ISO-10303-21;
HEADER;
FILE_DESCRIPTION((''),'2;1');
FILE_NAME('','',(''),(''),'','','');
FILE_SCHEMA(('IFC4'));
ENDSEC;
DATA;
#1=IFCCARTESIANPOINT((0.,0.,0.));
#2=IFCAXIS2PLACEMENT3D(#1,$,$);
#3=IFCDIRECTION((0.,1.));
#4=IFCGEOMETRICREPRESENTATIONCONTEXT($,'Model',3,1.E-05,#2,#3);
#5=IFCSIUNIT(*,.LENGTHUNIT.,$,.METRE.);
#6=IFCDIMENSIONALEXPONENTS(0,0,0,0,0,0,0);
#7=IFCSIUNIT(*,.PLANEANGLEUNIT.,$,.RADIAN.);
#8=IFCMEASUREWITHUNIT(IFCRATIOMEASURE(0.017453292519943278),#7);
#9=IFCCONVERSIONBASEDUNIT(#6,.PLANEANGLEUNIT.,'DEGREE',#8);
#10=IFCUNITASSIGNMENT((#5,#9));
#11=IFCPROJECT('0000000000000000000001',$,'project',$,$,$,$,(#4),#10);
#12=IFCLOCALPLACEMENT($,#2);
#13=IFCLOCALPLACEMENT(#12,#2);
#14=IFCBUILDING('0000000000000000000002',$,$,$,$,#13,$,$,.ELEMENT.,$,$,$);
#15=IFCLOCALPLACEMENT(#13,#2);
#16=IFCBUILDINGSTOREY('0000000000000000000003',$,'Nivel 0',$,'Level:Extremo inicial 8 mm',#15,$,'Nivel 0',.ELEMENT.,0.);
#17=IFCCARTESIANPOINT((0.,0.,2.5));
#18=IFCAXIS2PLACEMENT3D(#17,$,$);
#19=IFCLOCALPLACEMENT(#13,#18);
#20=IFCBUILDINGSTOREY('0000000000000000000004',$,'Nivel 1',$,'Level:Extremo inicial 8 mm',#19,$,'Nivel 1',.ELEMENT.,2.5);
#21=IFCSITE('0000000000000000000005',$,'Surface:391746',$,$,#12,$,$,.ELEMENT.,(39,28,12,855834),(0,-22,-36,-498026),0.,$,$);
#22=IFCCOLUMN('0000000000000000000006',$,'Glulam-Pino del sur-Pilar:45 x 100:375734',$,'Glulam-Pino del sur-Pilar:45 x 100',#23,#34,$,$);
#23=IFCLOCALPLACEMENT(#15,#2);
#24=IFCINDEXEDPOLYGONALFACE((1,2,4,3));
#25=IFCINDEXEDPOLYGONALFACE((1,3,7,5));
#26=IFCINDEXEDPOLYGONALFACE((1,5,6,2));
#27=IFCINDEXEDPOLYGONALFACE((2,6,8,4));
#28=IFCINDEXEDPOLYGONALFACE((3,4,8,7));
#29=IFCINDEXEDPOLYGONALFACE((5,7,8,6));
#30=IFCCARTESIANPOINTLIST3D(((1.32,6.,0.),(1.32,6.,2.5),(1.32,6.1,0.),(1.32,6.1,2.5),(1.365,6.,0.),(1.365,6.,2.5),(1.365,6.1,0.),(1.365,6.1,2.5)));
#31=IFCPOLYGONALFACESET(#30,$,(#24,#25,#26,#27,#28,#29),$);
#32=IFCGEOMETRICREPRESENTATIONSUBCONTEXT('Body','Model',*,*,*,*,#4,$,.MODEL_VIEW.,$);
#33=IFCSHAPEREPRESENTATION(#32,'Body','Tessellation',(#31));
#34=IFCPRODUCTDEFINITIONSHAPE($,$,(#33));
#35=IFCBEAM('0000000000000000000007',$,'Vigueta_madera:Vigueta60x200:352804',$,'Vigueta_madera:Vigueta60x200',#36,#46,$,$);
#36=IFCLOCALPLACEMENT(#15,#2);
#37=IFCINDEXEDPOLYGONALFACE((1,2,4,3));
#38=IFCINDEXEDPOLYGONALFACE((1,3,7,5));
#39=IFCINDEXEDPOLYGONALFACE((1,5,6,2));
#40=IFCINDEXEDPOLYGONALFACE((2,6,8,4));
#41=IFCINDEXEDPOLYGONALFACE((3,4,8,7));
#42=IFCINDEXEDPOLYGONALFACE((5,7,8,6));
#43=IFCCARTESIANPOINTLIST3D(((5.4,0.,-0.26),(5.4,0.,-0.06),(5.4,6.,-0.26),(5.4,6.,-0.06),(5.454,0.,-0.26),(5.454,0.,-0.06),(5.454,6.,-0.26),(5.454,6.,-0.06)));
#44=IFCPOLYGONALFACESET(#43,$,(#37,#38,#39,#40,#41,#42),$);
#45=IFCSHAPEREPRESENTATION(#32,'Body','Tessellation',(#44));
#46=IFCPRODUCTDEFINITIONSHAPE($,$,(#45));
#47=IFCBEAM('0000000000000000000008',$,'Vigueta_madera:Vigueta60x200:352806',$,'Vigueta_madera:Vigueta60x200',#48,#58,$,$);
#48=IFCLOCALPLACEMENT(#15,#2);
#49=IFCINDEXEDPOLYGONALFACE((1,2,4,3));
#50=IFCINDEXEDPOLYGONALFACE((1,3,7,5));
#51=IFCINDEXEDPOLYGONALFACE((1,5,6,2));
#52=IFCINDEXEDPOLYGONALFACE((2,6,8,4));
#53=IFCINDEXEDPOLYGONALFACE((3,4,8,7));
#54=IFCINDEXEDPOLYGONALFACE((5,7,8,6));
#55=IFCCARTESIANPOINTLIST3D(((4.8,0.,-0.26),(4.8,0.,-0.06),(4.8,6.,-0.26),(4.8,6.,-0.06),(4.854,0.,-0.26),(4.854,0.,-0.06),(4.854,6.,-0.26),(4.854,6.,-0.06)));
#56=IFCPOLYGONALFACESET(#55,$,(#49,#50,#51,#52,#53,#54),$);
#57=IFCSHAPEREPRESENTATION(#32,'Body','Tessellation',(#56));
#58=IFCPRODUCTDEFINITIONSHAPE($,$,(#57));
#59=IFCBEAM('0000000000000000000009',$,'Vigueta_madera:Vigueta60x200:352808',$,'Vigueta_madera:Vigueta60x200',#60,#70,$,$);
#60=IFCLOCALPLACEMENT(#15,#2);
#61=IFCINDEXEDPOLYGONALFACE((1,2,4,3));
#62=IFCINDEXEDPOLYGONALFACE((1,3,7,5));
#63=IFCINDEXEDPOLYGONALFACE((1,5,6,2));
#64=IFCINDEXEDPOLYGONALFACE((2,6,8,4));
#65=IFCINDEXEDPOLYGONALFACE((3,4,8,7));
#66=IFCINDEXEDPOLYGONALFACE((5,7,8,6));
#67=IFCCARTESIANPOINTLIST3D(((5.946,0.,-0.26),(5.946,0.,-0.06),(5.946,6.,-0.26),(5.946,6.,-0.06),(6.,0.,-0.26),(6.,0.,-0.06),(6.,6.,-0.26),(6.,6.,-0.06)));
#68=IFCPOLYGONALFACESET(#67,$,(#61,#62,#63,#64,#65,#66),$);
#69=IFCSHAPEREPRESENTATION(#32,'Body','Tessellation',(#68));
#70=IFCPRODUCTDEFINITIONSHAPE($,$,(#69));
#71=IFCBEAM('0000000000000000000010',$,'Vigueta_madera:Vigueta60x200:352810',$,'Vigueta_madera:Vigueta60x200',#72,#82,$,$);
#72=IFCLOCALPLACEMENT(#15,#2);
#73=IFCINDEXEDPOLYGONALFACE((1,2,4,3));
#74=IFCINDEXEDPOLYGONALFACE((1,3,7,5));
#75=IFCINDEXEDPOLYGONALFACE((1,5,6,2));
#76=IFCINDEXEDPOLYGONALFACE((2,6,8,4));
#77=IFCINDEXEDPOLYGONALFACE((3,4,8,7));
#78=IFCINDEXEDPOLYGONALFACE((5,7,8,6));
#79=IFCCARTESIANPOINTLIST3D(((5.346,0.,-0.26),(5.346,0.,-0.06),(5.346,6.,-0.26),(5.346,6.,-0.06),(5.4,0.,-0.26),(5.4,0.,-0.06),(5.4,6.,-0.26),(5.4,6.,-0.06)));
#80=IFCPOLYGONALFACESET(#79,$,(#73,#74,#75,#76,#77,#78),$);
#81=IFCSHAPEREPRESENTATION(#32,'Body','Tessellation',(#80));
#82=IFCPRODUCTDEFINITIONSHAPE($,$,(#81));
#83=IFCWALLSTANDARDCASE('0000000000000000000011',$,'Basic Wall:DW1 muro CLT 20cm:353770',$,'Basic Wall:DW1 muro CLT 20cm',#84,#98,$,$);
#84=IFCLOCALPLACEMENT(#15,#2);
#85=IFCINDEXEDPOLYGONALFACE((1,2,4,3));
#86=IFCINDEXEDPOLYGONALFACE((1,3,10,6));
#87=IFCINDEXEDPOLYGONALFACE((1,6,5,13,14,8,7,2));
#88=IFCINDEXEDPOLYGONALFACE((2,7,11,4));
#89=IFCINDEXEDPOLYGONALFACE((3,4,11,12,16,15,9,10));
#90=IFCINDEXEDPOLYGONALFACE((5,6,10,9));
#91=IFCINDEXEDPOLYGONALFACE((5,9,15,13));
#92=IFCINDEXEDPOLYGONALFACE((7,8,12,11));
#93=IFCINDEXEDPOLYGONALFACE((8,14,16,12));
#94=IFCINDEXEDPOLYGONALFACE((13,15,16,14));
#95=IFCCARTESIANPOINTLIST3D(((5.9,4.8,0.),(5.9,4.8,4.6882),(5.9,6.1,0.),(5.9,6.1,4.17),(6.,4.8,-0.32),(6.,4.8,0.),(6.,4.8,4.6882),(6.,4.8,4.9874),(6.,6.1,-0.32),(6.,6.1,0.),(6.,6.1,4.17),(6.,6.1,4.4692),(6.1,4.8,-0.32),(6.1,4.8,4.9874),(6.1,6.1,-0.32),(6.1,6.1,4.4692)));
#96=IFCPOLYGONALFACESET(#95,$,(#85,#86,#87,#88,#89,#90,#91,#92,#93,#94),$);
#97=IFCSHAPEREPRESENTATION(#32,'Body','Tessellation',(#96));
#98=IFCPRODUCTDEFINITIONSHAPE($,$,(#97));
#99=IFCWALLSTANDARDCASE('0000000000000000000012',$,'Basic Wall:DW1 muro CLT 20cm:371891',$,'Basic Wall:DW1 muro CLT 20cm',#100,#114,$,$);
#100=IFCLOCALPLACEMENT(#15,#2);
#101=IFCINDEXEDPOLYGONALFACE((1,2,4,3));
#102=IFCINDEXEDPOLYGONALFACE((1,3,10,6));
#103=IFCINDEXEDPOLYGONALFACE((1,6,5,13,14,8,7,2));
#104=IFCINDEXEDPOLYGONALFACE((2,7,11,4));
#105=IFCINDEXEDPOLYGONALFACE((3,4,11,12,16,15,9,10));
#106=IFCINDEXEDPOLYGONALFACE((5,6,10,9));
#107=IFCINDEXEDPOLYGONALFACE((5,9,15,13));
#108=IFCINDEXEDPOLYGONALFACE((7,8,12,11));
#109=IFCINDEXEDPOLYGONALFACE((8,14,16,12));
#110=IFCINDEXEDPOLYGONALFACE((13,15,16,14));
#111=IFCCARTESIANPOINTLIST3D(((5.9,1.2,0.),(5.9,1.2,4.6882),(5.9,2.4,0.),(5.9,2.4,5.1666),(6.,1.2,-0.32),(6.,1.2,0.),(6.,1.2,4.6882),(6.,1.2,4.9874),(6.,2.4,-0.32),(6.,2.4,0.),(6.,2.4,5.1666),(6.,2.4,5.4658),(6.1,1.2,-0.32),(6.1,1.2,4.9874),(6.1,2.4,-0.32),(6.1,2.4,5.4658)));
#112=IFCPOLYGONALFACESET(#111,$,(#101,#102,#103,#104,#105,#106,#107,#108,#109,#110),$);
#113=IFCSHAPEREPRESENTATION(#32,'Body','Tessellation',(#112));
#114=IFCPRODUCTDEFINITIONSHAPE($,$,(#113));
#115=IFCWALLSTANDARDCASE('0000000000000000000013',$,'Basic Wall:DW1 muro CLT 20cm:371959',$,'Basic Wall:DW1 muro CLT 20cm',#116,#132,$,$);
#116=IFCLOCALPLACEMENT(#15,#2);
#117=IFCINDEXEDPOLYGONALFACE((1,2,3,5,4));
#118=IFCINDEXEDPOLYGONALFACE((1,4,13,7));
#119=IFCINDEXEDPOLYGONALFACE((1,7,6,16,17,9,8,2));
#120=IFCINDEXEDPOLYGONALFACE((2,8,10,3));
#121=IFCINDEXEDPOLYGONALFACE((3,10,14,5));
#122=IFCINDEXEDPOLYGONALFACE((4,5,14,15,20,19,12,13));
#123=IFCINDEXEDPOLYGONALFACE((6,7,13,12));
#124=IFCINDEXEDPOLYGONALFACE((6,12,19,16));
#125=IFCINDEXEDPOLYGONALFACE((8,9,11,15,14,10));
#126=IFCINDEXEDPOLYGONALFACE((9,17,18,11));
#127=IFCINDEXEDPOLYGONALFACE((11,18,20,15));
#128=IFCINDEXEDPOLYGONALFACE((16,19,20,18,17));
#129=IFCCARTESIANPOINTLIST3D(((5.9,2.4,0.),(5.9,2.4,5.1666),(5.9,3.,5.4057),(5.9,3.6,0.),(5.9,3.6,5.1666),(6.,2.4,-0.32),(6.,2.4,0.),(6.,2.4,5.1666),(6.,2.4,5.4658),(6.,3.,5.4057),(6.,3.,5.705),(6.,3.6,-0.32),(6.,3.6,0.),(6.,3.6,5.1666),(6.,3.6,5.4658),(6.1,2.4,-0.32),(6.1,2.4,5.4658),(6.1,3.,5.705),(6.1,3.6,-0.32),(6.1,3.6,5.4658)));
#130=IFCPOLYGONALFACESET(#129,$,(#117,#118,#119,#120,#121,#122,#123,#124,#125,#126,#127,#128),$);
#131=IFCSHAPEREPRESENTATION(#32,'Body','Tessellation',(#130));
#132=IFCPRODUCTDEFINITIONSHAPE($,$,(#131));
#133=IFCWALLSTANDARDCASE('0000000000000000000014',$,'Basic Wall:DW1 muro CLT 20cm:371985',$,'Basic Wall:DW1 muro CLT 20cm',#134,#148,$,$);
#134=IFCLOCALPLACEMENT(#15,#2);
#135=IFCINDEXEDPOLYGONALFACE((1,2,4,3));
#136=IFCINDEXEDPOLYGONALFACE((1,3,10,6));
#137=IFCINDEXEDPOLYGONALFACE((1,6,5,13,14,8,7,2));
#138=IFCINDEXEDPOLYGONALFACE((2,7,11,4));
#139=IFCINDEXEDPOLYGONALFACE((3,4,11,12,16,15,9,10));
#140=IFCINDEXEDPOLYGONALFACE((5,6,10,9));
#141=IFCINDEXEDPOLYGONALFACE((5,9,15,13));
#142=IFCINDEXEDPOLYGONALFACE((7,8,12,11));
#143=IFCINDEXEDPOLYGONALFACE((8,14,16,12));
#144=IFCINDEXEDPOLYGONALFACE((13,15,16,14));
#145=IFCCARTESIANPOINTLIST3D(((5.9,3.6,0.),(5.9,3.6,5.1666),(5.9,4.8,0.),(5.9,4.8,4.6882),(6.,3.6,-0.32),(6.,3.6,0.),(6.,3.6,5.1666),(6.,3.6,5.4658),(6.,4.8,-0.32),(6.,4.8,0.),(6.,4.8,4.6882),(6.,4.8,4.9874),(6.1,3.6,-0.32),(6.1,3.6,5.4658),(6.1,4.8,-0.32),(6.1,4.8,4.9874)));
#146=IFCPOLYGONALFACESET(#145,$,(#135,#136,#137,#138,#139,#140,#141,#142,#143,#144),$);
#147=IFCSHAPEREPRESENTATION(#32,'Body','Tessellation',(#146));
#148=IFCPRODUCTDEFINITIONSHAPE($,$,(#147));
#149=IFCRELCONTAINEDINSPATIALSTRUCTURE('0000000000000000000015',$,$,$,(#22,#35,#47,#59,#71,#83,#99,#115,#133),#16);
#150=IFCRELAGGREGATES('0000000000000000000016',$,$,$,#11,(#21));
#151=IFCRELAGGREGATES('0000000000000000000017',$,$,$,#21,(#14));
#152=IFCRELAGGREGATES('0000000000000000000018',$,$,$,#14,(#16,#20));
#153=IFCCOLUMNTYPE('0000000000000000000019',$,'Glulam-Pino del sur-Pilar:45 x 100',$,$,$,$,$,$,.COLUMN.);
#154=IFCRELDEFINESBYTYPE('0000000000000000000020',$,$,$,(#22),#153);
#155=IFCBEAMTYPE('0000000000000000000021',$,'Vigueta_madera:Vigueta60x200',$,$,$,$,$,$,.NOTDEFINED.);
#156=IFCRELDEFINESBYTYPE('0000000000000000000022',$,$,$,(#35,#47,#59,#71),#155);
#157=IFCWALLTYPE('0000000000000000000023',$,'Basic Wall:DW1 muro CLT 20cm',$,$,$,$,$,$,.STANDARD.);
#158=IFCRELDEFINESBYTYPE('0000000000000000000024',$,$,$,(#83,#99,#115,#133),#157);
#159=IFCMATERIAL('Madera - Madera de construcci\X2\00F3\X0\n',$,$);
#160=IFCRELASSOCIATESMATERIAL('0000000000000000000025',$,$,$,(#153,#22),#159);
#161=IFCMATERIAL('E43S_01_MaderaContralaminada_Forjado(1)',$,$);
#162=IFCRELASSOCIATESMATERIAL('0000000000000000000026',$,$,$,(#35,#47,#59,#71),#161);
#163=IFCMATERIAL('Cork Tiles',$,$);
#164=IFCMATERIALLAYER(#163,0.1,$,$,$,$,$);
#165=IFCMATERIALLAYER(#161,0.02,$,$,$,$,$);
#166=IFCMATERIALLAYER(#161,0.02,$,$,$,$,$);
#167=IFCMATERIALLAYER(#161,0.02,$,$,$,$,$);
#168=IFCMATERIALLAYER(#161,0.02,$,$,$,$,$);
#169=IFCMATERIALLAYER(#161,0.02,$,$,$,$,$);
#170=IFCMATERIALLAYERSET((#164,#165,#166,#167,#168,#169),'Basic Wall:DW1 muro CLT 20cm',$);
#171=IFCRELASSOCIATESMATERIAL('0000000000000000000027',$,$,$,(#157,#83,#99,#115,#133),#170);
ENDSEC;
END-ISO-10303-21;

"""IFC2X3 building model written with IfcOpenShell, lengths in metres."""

from ifc_helpers import new_model, entity, si_unit, converted_unit, direction, frame, frame_2d, origin, origin_2d_with_axis, place, context, subcontext, project, spatial, polyline, rectangle, extrude, clip, bounded_halfspace, source, transform, mapped, material, layer, layer_set, layer_usage, type_object, type_shapes, element, save


model = new_model("IFC2X3")

# Units and contexts
model_context = context("Model", 3, precision=1e-05, world=origin(), true_north=direction((0.0, 1.0)))
body_context = subcontext(model_context, "Body", "Model", "MODEL_VIEW")
ifc_project = project(units=[si_unit("LENGTHUNIT", "METRE"), converted_unit("PLANEANGLEUNIT", "DEGREE", entity("IfcRatioMeasure", 0.017453292519943278), si_unit("PLANEANGLEUNIT", "RADIAN"), dimensions=[0, 0, 0, 0, 0, 0, 0])], contexts=[model_context])

# Site, building, storey
site_placement = place(None, origin())
site = spatial("IfcSite", under=ifc_project, at=site_placement, Name="Surface:391746", CompositionType="ELEMENT", RefLatitude=(39, 28, 12, 855834), RefLongitude=(0, -22, -36, -498026), RefElevation=0.0)
building_placement = place(site_placement, origin())
building = spatial("IfcBuilding", under=site, at=building_placement, CompositionType="ELEMENT")
storey_1_placement = place(building_placement, origin())
storey_1 = spatial("IfcBuildingStorey", under=building, at=storey_1_placement, Name="Nivel 0", ObjectType="Level:Extremo inicial 8 mm", LongName="Nivel 0", CompositionType="ELEMENT", Elevation=0.0)

# Column
ifc_material_1 = material(Name="Madera - Madera de construcción")
column_type = type_object("IfcColumnType", Name="Glulam-Pino del sur-Pilar:45 x 100", PredefinedType="COLUMN", material=ifc_material_1)
shared_shape_1 = source(origin(), body_context, "Body", "SweptSolid", [
    extrude(rectangle(XDim=0.1, YDim=0.045, at=origin_2d_with_axis()), frame((0.0, 0.0, 0.0), z_axis=(0.0, 0.0, 1.0), x_axis=(0.0, -1.0, 0.0)), (0.0, 0.0, 1.0), 2.5),
])
type_shapes(column_type, [shared_shape_1])
column_placement = place(storey_1_placement, frame((1.3425, 6.05, 0.0), z_axis=(0.0, 0.0, 1.0), x_axis=(-1.0, 0.0, 0.0)))
element("IfcColumn", 1, at=column_placement, inside=storey_1, type_object=column_type, material=ifc_material_1, Name="Glulam-Pino del sur-Pilar:45 x 100:375734", ObjectType="Glulam-Pino del sur-Pilar:45 x 100", context=body_context, shape_type="MappedRepresentation", body=[
    mapped(shared_shape_1, transform((0.0, 0.0, 0.0), scale=1.0)),
])

# Beams
ifc_material_2 = material(Name="E43S_01_MaderaContralaminada_Forjado(1)")
beam_type = type_object("IfcBeamType", Name="Vigueta_madera:Vigueta60x200", PredefinedType="NOTDEFINED")
beam_1_placement = place(storey_1_placement, frame((5.427, 0.0, -0.06), z_axis=(0.0, 0.0, 1.0), x_axis=(0.0, 1.0, 0.0)))
element("IfcBeam", 2, at=beam_1_placement, inside=storey_1, type_object=beam_type, material=ifc_material_2, Name="Vigueta_madera:Vigueta60x200:352804", ObjectType="Vigueta_madera:Vigueta60x200", context=body_context, shape_type="SweptSolid", body=[
    extrude(rectangle(XDim=0.2, YDim=0.054, at=frame_2d((0.0, 0.0), x_axis=(1.0, 0.0))), frame((0.0, 0.0, -0.1), z_axis=(1.0, 0.0, 0.0), x_axis=(0.0, 0.0, -1.0)), (0.0, 0.0, 1.0), 6.0),
])
beam_2_placement = place(storey_1_placement, frame((4.827, 0.0, -0.06), z_axis=(0.0, 0.0, 1.0), x_axis=(0.0, 1.0, 0.0)))
element("IfcBeam", 3, at=beam_2_placement, inside=storey_1, type_object=beam_type, material=ifc_material_2, Name="Vigueta_madera:Vigueta60x200:352806", ObjectType="Vigueta_madera:Vigueta60x200", context=body_context, shape_type="SweptSolid", body=[
    extrude(rectangle(XDim=0.2, YDim=0.054, at=frame_2d((0.0, 0.0), x_axis=(1.0, 0.0))), frame((0.0, 0.0, -0.1), z_axis=(1.0, 0.0, 0.0), x_axis=(0.0, 0.0, -1.0)), (0.0, 0.0, 1.0), 6.0),
])
beam_3_placement = place(storey_1_placement, frame((5.973, 0.0, -0.06), z_axis=(0.0, 0.0, 1.0), x_axis=(0.0, 1.0, 0.0)))
element("IfcBeam", 4, at=beam_3_placement, inside=storey_1, type_object=beam_type, material=ifc_material_2, Name="Vigueta_madera:Vigueta60x200:352808", ObjectType="Vigueta_madera:Vigueta60x200", context=body_context, shape_type="SweptSolid", body=[
    extrude(rectangle(XDim=0.2, YDim=0.054, at=origin_2d_with_axis()), frame((0.0, 0.0, -0.1), z_axis=(1.0, 0.0, 0.0), x_axis=(0.0, 0.0, -1.0)), (0.0, 0.0, 1.0), 6.0),
])
beam_4_placement = place(storey_1_placement, frame((5.373, 0.0, -0.06), z_axis=(0.0, 0.0, 1.0), x_axis=(0.0, 1.0, 0.0)))
element("IfcBeam", 5, at=beam_4_placement, inside=storey_1, type_object=beam_type, material=ifc_material_2, Name="Vigueta_madera:Vigueta60x200:352810", ObjectType="Vigueta_madera:Vigueta60x200", context=body_context, shape_type="SweptSolid", body=[
    extrude(rectangle(XDim=0.2, YDim=0.054, at=origin_2d_with_axis()), frame((0.0, 0.0, -0.1), z_axis=(1.0, 0.0, 0.0), x_axis=(0.0, 0.0, -1.0)), (0.0, 0.0, 1.0), 6.0),
])

# Walls
ifc_material_3 = material(Name="Cork Tiles")
ifc_layer_1 = layer(ifc_material_3, 0.1)
ifc_layer_2 = layer(ifc_material_2, 0.02)
ifc_layer_3 = layer(ifc_material_2, 0.02)
ifc_layer_4 = layer(ifc_material_2, 0.02)
ifc_layer_5 = layer(ifc_material_2, 0.02)
ifc_layer_6 = layer(ifc_material_2, 0.02)
ifc_layer_set_1 = layer_set([ifc_layer_1, ifc_layer_2, ifc_layer_3, ifc_layer_4, ifc_layer_5, ifc_layer_6], Name="Basic Wall:DW1 muro CLT 20cm")
ifc_layer_usage_1 = layer_usage(ifc_layer_set_1, "AXIS2", "NEGATIVE", 0.1)
wall_type_1 = type_object("IfcWallType", Name="Basic Wall:DW1 muro CLT 20cm", PredefinedType="STANDARD", material=ifc_layer_set_1)
wall_1_placement = place(storey_1_placement, frame((6.0, 6.1, -0.32), z_axis=(0.0, 0.0, 1.0), x_axis=(0.0, -1.0, 0.0)))
element("IfcWallStandardCase", 6, at=wall_1_placement, inside=storey_1, type_object=wall_type_1, material=ifc_layer_usage_1, Name="Basic Wall:DW1 muro CLT 20cm:353770", ObjectType="Basic Wall:DW1 muro CLT 20cm", context=body_context, shape_type="Clipping", body=[
    clip(clip(clip(extrude(rectangle(XDim=1.3, YDim=0.2, at=frame_2d((0.65, 0.0), x_axis=(-1.0, 0.0))), origin(), (0.0, 0.0, 1.0), 5.3074), bounded_halfspace(frame((0.0, -0.1, 4.49), z_axis=(-0.370288, 0.0, 0.928917), x_axis=(0.0, -1.0, 0.0)), False, frame((0.0, -0.1, 4.49)), polyline([(0.0, 0.0), (0.2, 0.0), (1.3, 0.0), (1.3, 0.1), (0.0, 0.1), (0.0, 0.0)]))), bounded_halfspace(frame((1.3, 0.0, 5.3074), z_axis=(-0.370288, 0.0, 0.928917), x_axis=(0.0, -1.0, 0.0)), False, frame((1.3, 0.0, 5.3074)), polyline([(0.0, 0.0), (0.0, 0.1), (-1.3, 0.1), (-1.3, 0.0), (0.0, 0.0)]))), bounded_halfspace(frame((1.3, -0.1, 0.32), z_axis=(0.0, 0.0, -1.0), x_axis=(0.0, 1.0, 0.0)), False, frame((1.3, -0.1, 0.32)), polyline([(0.0, 0.0), (0.0, 0.1), (-1.3, 0.1), (-1.3, 0.0), (-1.2, 0.0), (-1.1, 0.0), (0.0, 0.0)]))),
])
ifc_layer_usage_2 = layer_usage(ifc_layer_set_1, "AXIS2", "NEGATIVE", 0.1)
wall_2_placement = place(storey_1_placement, frame((6.0, 2.4, -0.32), z_axis=(0.0, 0.0, 1.0), x_axis=(0.0, -1.0, 0.0)))
element("IfcWallStandardCase", 7, at=wall_2_placement, inside=storey_1, type_object=wall_type_1, material=ifc_layer_usage_2, Name="Basic Wall:DW1 muro CLT 20cm:371891", ObjectType="Basic Wall:DW1 muro CLT 20cm", context=body_context, shape_type="Clipping", body=[
    clip(clip(clip(extrude(rectangle(XDim=1.2, YDim=0.2, at=frame_2d((0.6, 0.0), x_axis=(-1.0, 0.0))), origin(), (0.0, 0.0, 1.0), 5.7858), bounded_halfspace(frame((0.0, -0.1, 5.4866), z_axis=(0.370288, 0.0, 0.928917), x_axis=(0.0, 1.0, 0.0)), False, frame((0.0, -0.1, 5.4866)), polyline([(0.0, 0.0), (1.2, 0.0), (1.2, 0.1), (0.0, 0.1), (0.0, 0.0)]))), bounded_halfspace(frame((1.2, 0.0, 5.3074), z_axis=(0.370288, 0.0, 0.928917), x_axis=(0.0, 1.0, 0.0)), False, frame((1.2, 0.0, 5.3074)), polyline([(0.0, 0.0), (0.0, 0.1), (-1.2, 0.1), (-1.2, 0.0), (0.0, 0.0)]))), bounded_halfspace(frame((1.2, -0.1, 0.32), z_axis=(0.0, 0.0, -1.0), x_axis=(0.0, 1.0, 0.0)), False, frame((1.2, -0.1, 0.32)), polyline([(0.0, 0.0), (0.0, 0.1), (-1.2, 0.1), (-1.2, 0.0), (0.0, 0.0)]))),
])
ifc_layer_usage_3 = layer_usage(ifc_layer_set_1, "AXIS2", "NEGATIVE", 0.1)
wall_3_placement = place(storey_1_placement, frame((6.0, 3.6, -0.32), z_axis=(0.0, 0.0, 1.0), x_axis=(0.0, -1.0, 0.0)))
element("IfcWallStandardCase", 8, at=wall_3_placement, inside=storey_1, type_object=wall_type_1, material=ifc_layer_usage_3, Name="Basic Wall:DW1 muro CLT 20cm:371959", ObjectType="Basic Wall:DW1 muro CLT 20cm", context=body_context, shape_type="Clipping", body=[
    clip(clip(clip(clip(clip(extrude(rectangle(XDim=1.2, YDim=0.2, at=frame_2d((0.6, 0.0), x_axis=(-1.0, 0.0))), origin(), (0.0, 0.0, 1.0), 6.025), bounded_halfspace(frame((0.6, -0.1, 5.7257), z_axis=(0.370288, 0.0, 0.928917), x_axis=(0.0, 1.0, 0.0)), False, frame((0.6, -0.1, 5.7257)), polyline([(0.0, 0.0), (0.6, 0.0), (0.6, 0.1), (0.0, 0.1), (0.0, 0.0)]))), bounded_halfspace(frame((0.0, -0.1, 5.4866), z_axis=(-0.370288, 0.0, 0.928917), x_axis=(0.0, -1.0, 0.0)), False, frame((0.0, -0.1, 5.4866)), polyline([(0.0, 0.0), (0.6, 0.0), (0.6, 0.1), (0.0, 0.1), (0.0, 0.0)]))), bounded_halfspace(frame((1.2, 0.0, 5.7858), z_axis=(0.370288, 0.0, 0.928917), x_axis=(0.0, 1.0, 0.0)), False, frame((1.2, 0.0, 5.7858)), polyline([(0.0, 0.0), (0.0, 0.1), (-0.6, 0.1), (-0.6, 0.0), (0.0, 0.0)]))), bounded_halfspace(frame((0.6, 0.0, 6.025), z_axis=(-0.370288, 0.0, 0.928917), x_axis=(0.0, -1.0, 0.0)), False, frame((0.6, 0.0, 6.025)), polyline([(0.0, 0.0), (0.0, 0.1), (-0.6, 0.1), (-0.6, 0.0), (0.0, 0.0)]))), bounded_halfspace(frame((1.2, -0.1, 0.32), z_axis=(0.0, 0.0, -1.0), x_axis=(0.0, 1.0, 0.0)), False, frame((1.2, -0.1, 0.32)), polyline([(0.0, 0.0), (0.0, 0.1), (-1.2, 0.1), (-1.2, 0.0), (0.0, 0.0)]))),
])
ifc_layer_usage_4 = layer_usage(ifc_layer_set_1, "AXIS2", "NEGATIVE", 0.1)
wall_4_placement = place(storey_1_placement, frame((6.0, 4.8, -0.32), z_axis=(0.0, 0.0, 1.0), x_axis=(0.0, -1.0, 0.0)))
element("IfcWallStandardCase", 9, at=wall_4_placement, inside=storey_1, type_object=wall_type_1, material=ifc_layer_usage_4, Name="Basic Wall:DW1 muro CLT 20cm:371985", ObjectType="Basic Wall:DW1 muro CLT 20cm", context=body_context, shape_type="Clipping", body=[
    clip(clip(clip(extrude(rectangle(XDim=1.2, YDim=0.2, at=frame_2d((0.6, 0.0), x_axis=(-1.0, 0.0))), origin(), (0.0, 0.0, 1.0), 5.7858), bounded_halfspace(frame((0.0, -0.1, 5.0082), z_axis=(-0.370288, 0.0, 0.928917), x_axis=(0.0, -1.0, 0.0)), False, frame((0.0, -0.1, 5.0082)), polyline([(0.0, 0.0), (1.2, 0.0), (1.2, 0.1), (0.0, 0.1), (0.0, 0.0)]))), bounded_halfspace(frame((1.2, 0.0, 5.7858), z_axis=(-0.370288, 0.0, 0.928917), x_axis=(0.0, -1.0, 0.0)), False, frame((1.2, 0.0, 5.7858)), polyline([(0.0, 0.0), (0.0, 0.1), (-1.2, 0.1), (-1.2, 0.0), (0.0, 0.0)]))), bounded_halfspace(frame((1.2, -0.1, 0.32), z_axis=(0.0, 0.0, -1.0), x_axis=(0.0, 1.0, 0.0)), False, frame((1.2, -0.1, 0.32)), polyline([(0.0, 0.0), (0.0, 0.1), (-1.2, 0.1), (-1.2, 0.0), (0.0, 0.0)]))),
])

# Shared definitions
storey_2_placement = place(building_placement, frame((0.0, 0.0, 2.5)))
storey_2 = spatial("IfcBuildingStorey", under=building, at=storey_2_placement, Name="Nivel 1", ObjectType="Level:Extremo inicial 8 mm", LongName="Nivel 1", CompositionType="ELEMENT", Elevation=2.5)

save(model, "model.ifc")
